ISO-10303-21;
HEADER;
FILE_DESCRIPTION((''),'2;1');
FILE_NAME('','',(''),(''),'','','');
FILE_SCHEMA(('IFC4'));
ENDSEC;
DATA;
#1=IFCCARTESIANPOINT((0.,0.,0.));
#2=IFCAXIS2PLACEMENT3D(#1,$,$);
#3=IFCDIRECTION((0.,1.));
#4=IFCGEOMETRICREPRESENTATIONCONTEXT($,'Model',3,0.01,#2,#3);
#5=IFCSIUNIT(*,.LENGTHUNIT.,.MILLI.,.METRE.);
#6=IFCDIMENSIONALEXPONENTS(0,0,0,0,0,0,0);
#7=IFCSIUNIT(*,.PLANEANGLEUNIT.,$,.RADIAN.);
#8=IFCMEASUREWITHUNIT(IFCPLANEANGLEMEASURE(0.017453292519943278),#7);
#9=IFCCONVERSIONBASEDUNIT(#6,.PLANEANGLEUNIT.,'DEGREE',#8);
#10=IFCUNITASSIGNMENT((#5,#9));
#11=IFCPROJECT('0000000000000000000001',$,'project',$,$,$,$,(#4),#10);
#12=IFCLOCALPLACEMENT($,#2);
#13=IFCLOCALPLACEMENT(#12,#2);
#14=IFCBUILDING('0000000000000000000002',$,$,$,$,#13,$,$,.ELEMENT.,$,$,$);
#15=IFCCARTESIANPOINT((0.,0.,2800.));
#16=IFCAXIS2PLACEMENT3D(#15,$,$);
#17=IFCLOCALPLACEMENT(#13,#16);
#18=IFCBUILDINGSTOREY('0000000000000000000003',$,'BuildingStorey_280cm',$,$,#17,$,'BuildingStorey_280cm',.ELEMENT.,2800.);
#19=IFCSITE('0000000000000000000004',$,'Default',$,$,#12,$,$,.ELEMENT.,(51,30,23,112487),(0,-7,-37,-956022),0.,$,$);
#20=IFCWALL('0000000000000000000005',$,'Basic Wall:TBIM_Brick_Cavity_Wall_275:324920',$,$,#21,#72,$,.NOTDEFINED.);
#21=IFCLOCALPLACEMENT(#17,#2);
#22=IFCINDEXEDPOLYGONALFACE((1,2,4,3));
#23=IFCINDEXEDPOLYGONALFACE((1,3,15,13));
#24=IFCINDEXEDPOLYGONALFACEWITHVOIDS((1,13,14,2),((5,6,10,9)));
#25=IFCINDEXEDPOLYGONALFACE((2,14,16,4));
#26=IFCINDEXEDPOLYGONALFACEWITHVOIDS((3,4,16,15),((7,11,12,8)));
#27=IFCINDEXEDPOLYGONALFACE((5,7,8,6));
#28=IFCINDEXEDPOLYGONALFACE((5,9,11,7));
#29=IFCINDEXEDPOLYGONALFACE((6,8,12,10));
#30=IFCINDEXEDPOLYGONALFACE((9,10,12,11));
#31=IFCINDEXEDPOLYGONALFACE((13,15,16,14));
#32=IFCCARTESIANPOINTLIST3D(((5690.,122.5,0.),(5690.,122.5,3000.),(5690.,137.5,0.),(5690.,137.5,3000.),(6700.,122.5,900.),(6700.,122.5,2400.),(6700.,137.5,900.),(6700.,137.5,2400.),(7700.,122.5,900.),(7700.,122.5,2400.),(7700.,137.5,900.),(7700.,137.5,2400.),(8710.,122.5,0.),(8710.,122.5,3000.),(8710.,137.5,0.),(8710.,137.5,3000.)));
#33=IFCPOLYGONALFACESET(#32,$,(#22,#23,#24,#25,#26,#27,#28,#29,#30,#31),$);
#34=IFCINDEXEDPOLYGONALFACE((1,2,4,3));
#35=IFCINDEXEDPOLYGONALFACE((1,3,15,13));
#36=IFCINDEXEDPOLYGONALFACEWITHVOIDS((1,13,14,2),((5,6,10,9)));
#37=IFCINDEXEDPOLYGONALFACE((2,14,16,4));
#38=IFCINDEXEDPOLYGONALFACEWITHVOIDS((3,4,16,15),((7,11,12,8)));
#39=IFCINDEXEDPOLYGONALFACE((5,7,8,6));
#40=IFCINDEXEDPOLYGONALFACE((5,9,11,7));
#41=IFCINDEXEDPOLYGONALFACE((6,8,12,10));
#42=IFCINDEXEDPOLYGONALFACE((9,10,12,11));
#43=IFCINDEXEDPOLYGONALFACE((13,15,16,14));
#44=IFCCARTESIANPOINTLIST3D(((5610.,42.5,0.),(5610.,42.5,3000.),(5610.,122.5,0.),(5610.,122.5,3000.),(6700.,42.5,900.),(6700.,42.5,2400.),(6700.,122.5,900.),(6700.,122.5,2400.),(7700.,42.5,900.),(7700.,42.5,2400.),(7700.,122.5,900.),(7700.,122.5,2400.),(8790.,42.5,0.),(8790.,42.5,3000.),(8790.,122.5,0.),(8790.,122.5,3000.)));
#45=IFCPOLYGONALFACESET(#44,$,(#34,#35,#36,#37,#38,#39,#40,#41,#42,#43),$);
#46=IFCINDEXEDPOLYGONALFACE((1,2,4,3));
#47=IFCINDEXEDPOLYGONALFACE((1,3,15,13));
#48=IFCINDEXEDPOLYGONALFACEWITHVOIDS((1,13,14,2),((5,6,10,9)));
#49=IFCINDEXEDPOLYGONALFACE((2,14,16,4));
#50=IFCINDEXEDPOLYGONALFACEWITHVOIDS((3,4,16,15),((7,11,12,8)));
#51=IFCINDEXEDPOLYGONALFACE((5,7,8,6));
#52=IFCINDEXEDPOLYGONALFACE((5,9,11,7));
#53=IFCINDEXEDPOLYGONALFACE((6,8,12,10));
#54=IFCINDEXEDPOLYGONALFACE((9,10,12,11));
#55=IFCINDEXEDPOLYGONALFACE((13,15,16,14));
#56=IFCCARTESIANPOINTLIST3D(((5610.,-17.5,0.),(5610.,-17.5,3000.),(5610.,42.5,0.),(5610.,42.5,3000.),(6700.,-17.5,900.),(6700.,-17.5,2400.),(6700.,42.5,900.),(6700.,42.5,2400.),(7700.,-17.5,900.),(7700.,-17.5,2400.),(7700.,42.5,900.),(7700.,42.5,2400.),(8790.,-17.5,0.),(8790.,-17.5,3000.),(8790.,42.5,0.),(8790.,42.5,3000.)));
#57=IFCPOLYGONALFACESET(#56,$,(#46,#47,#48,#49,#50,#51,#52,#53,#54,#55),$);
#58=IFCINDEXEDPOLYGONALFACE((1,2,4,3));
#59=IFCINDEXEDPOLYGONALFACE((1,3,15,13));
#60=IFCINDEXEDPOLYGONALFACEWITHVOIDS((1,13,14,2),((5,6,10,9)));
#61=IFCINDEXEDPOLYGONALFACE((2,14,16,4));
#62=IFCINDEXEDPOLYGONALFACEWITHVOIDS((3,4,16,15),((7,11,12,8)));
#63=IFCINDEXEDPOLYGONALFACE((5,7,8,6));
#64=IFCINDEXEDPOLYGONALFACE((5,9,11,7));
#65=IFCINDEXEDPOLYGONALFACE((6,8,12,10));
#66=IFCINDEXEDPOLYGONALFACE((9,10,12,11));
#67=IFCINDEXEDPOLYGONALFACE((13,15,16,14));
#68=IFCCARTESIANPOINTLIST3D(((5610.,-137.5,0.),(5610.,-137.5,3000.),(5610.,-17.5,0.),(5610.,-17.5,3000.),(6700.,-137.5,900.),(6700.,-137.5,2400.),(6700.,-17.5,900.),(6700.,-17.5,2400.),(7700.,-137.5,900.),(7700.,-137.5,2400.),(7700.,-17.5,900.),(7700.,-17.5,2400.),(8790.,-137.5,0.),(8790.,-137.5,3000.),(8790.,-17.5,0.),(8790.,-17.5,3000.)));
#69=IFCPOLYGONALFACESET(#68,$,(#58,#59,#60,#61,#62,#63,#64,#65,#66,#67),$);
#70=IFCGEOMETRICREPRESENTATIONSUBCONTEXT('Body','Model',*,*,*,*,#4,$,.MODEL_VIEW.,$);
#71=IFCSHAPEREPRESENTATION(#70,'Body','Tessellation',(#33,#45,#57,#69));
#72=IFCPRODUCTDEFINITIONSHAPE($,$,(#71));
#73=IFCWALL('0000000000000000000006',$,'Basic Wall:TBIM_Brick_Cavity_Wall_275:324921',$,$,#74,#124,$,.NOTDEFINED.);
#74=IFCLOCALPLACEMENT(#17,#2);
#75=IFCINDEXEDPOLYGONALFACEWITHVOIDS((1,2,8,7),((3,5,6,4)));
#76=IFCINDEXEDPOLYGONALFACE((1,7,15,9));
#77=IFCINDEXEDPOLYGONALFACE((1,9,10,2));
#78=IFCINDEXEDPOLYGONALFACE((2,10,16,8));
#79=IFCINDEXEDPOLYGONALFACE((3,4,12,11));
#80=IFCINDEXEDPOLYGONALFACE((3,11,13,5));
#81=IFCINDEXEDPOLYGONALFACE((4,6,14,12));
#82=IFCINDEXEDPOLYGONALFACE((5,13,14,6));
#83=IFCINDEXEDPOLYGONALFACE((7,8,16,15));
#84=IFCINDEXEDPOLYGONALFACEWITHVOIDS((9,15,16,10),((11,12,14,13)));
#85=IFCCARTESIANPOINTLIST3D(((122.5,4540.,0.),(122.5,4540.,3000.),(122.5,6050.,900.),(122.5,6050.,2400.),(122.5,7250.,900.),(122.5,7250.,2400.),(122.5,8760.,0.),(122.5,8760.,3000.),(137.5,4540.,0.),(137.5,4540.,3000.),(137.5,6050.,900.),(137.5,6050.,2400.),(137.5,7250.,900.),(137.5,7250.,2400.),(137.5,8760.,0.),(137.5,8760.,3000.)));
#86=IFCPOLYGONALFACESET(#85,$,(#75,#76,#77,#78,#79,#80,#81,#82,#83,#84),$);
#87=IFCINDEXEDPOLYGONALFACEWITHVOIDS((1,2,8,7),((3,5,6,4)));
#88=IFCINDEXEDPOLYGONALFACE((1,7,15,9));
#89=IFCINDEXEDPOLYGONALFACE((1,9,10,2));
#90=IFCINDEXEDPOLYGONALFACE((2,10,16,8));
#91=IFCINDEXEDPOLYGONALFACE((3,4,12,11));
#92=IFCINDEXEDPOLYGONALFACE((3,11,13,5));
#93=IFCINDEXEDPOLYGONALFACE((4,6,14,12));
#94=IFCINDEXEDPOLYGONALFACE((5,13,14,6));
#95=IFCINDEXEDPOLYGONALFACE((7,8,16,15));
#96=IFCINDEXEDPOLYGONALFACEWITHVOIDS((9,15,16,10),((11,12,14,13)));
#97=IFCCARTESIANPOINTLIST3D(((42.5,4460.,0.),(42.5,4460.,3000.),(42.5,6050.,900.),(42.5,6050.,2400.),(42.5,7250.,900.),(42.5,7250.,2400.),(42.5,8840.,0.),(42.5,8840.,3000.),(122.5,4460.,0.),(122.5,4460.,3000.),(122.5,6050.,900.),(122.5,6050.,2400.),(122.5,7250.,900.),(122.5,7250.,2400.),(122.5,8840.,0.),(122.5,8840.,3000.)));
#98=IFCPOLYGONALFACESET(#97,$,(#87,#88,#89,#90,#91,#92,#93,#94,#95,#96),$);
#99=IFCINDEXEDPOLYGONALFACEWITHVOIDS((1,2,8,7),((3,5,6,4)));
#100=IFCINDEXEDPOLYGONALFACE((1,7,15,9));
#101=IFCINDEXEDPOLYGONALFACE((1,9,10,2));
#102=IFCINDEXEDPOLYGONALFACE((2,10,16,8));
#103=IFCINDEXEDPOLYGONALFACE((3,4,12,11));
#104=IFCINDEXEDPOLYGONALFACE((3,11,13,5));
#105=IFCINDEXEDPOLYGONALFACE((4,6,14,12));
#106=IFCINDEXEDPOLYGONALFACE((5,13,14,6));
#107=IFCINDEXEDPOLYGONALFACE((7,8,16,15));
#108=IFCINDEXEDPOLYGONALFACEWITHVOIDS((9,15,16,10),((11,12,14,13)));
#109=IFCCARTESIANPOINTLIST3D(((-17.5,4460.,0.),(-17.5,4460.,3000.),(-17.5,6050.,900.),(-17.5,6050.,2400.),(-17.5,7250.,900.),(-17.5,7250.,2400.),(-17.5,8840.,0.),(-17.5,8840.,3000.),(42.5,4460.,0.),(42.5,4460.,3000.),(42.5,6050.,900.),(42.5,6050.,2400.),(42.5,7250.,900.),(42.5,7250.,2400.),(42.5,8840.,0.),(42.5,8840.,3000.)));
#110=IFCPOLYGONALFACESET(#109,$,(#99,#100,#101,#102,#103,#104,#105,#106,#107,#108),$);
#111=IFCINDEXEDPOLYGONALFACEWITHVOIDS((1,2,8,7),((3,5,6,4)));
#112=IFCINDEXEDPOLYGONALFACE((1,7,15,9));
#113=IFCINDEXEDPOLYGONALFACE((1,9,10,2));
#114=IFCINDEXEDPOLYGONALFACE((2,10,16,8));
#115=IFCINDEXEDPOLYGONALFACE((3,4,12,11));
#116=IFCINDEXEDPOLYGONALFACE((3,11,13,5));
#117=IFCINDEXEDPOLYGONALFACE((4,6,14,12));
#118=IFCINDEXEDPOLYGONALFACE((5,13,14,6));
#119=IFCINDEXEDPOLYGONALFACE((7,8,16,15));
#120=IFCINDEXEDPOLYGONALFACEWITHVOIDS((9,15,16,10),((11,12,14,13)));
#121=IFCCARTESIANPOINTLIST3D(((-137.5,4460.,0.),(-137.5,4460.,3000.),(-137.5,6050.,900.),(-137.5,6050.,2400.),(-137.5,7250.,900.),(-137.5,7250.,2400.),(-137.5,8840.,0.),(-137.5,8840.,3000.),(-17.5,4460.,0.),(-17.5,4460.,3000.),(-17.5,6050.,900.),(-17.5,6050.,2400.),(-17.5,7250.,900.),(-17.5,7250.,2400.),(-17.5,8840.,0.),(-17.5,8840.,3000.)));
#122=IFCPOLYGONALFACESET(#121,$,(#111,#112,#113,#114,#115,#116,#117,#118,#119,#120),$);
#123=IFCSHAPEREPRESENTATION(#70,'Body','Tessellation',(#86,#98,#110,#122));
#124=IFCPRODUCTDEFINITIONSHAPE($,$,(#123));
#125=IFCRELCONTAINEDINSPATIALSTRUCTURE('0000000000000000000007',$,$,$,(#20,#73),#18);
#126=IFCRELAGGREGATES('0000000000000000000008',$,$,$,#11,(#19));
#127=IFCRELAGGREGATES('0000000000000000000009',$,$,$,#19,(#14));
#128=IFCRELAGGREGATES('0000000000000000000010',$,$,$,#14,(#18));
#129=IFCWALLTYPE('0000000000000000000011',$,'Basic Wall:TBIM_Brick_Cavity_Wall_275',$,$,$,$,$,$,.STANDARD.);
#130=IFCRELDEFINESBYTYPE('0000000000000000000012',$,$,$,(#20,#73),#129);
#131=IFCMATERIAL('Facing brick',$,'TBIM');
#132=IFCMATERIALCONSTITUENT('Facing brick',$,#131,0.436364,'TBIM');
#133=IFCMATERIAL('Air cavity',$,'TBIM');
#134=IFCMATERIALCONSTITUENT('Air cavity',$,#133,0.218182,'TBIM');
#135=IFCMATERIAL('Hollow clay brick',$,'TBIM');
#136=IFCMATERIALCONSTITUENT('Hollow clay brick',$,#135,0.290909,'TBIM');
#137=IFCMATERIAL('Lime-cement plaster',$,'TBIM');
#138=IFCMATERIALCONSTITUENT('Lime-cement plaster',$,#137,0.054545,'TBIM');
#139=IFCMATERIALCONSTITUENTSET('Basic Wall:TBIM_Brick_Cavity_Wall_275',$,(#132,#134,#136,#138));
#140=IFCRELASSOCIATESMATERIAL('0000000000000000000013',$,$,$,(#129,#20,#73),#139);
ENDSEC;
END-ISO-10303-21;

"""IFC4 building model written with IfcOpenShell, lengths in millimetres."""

from ifc_helpers import new_model, entity, si_unit, converted_unit, direction, frame, origin, place, context, subcontext, project, spatial, indexed_curve, outline, extrude, material, constituent, constituent_set, type_object, element, save


model = new_model("IFC4")

# Units and contexts
model_context = context("Model", 3, precision=0.01, world=origin(), true_north=direction((0.0, 1.0)))
body_context = subcontext(model_context, "Body", "Model", "MODEL_VIEW")
ifc_project = project(units=[si_unit("LENGTHUNIT", "METRE", prefix="MILLI"), converted_unit("PLANEANGLEUNIT", "DEGREE", entity("IfcPlaneAngleMeasure", 0.017453292519943278), si_unit("PLANEANGLEUNIT", "RADIAN"), dimensions=[0, 0, 0, 0, 0, 0, 0])], contexts=[model_context])

# Site, building, storey
site_placement = place(None, origin())
site = spatial("IfcSite", under=ifc_project, at=site_placement, Name="Default", CompositionType="ELEMENT", RefLatitude=(51, 30, 23, 112487), RefLongitude=(0, -7, -37, -956022), RefElevation=0.0)
building_placement = place(site_placement, origin())
building = spatial("IfcBuilding", under=site, at=building_placement, CompositionType="ELEMENT")
storey_placement = place(building_placement, frame((0.0, 0.0, 2800.0)))
storey = spatial("IfcBuildingStorey", under=building, at=storey_placement, Name="BuildingStorey_280cm", LongName="BuildingStorey_280cm", CompositionType="ELEMENT", Elevation=2800.0)

# Shared definitions
ifc_material_1 = material(Name="Lime-cement plaster", Category="TBIM")

# Wall, opening
ifc_material_2 = material(Name="Facing brick", Category="TBIM")
ifc_constituent_1 = constituent(ifc_material_2, Name="Facing brick", Category="TBIM", fraction=0.436364)
ifc_material_3 = material(Name="Air cavity", Category="TBIM")
ifc_constituent_2 = constituent(ifc_material_3, Name="Air cavity", Category="TBIM", fraction=0.218182)
ifc_material_4 = material(Name="Hollow clay brick", Category="TBIM")
ifc_constituent_3 = constituent(ifc_material_4, Name="Hollow clay brick", Category="TBIM", fraction=0.290909)
ifc_constituent_4 = constituent(ifc_material_1, Name="Lime-cement plaster", Category="TBIM", fraction=0.054545)
ifc_constituent_set_1 = constituent_set(constituents=[ifc_constituent_1, ifc_constituent_2, ifc_constituent_3, ifc_constituent_4], Name="Basic Wall:TBIM_Brick_Cavity_Wall_275")
wall_type_1 = type_object("IfcWallType", Name="Basic Wall:TBIM_Brick_Cavity_Wall_275", PredefinedType="STANDARD", material=ifc_constituent_set_1)
wall_1_placement = place(storey_placement, frame((5595.0, 0.0, 0.0)))
wall_1 = element("IfcWall", 1, at=wall_1_placement, inside=storey, type_object=wall_type_1, material=ifc_constituent_set_1, Name="Basic Wall:TBIM_Brick_Cavity_Wall_275:324920", PredefinedType="NOTDEFINED", context=body_context, shape_type="SweptSolid", body=[
    extrude(outline(indexed_curve([(-1500.0, -1510.0), (1500.0, -1510.0), (1500.0, 1510.0), (-1500.0, 1510.0), (-1500.0, -1510.0)], self_intersect=False), holes=[indexed_curve([(-600.0, -500.0), (-600.0, 500.0), (900.0, 500.0), (900.0, -500.0), (-600.0, -500.0)], self_intersect=False)]), frame((1605.0, 122.5, 1500.0), z_axis=(0.0, 1.0, 0.0), x_axis=(0.0, 0.0, 1.0)), (0.0, 0.0, 1.0), 15.0),
    extrude(outline(indexed_curve([(-1500.0, -1590.0), (1500.0, -1590.0), (1500.0, 1590.0), (-1500.0, 1590.0), (-1500.0, -1590.0)], self_intersect=False), holes=[indexed_curve([(-600.0, -500.0), (-600.0, 500.0), (900.0, 500.0), (900.0, -500.0), (-600.0, -500.0)], self_intersect=False)]), frame((1605.0, 42.5, 1500.0), z_axis=(0.0, 1.0, 0.0), x_axis=(0.0, 0.0, 1.0)), (0.0, 0.0, 1.0), 80.0),
    extrude(outline(indexed_curve([(-1500.0, -1590.0), (1500.0, -1590.0), (1500.0, 1590.0), (-1500.0, 1590.0), (-1500.0, -1590.0)], self_intersect=False), holes=[indexed_curve([(-600.0, -500.0), (-600.0, 500.0), (900.0, 500.0), (900.0, -500.0), (-600.0, -500.0)], self_intersect=False)]), frame((1605.0, -17.5, 1500.0), z_axis=(0.0, 1.0, 0.0), x_axis=(0.0, 0.0, 1.0)), (0.0, 0.0, 1.0), 60.0),
    extrude(outline(indexed_curve([(-1500.0, -1590.0), (1500.0, -1590.0), (1500.0, 1590.0), (-1500.0, 1590.0), (-1500.0, -1590.0)], self_intersect=False), holes=[indexed_curve([(900.0, -500.0), (-600.0, -500.0), (-600.0, 500.0), (900.0, 500.0), (900.0, -500.0)], self_intersect=False)]), frame((1605.0, -137.5, 1500.0), z_axis=(0.0, 1.0, 0.0), x_axis=(0.0, 0.0, 1.0)), (0.0, 0.0, 1.0), 120.0),
])
opening_1_placement = place(wall_1_placement, frame((1105.0, -137.5, 900.0)))
element("IfcOpeningElement", 2, at=opening_1_placement, cuts=wall_1, PredefinedType="OPENING", context=body_context, shape_type="SweptSolid", body=[
    extrude(outline(indexed_curve([(1500.0, 0.0), (1500.0, 1000.0), (0.0, 1000.0), (0.0, 0.0), (1500.0, 0.0)], self_intersect=False)), frame((0.0, 0.0, 0.0), z_axis=(0.0, 1.0, 0.0), x_axis=(0.0, 0.0, 1.0)), (0.0, 0.0, 1.0), 275.0),
])

# Wall, openings
wall_2_placement = place(storey_placement, frame((0.0, 4445.0, 0.0), z_axis=(0.0, 0.0, 1.0), x_axis=(0.0, 1.0, 0.0)))
wall_2 = element("IfcWall", 3, at=wall_2_placement, inside=storey, type_object=wall_type_1, material=ifc_constituent_set_1, Name="Basic Wall:TBIM_Brick_Cavity_Wall_275:324921", PredefinedType="NOTDEFINED", context=body_context, shape_type="SweptSolid", body=[
    extrude(outline(indexed_curve([(-2095.0, -5.0), (2095.0, -5.0), (2110.0, -5.0), (2110.0, 10.0), (-2110.0, 10.0), (-2110.0, -5.0), (-2095.0, -5.0)], self_intersect=False)), frame((2205.0, -132.5, 0.0)), (0.0, 0.0, 1.0), 3000.0),
    extrude(outline(indexed_curve([(-1500.0, -2190.0), (1500.0, -2190.0), (1500.0, 2190.0), (-1500.0, 2190.0), (-1500.0, -2190.0)], self_intersect=False), holes=[indexed_curve([(-900.0, -600.0), (-900.0, 600.0), (600.0, 600.0), (600.0, -600.0), (-900.0, -600.0)], self_intersect=False)]), frame((2205.0, -42.5, 1500.0), z_axis=(0.0, -1.0, 0.0), x_axis=(0.0, 0.0, -1.0)), (0.0, 0.0, 1.0), 80.0),
    extrude(outline(indexed_curve([(-1500.0, -2190.0), (1500.0, -2190.0), (1500.0, 2190.0), (-1500.0, 2190.0), (-1500.0, -2190.0)], self_intersect=False), holes=[indexed_curve([(-900.0, -600.0), (-900.0, 600.0), (600.0, 600.0), (600.0, -600.0), (-900.0, -600.0)], self_intersect=False)]), frame((2205.0, 17.5, 1500.0), z_axis=(0.0, -1.0, 0.0), x_axis=(0.0, 0.0, -1.0)), (0.0, 0.0, 1.0), 60.0),
    extrude(outline(indexed_curve([(-60.0, -2190.0), (60.0, -2190.0), (60.0, 2190.0), (-60.0, 2190.0), (-60.0, -2190.0)], self_intersect=False)), frame((2205.0, 77.5, 0.0), z_axis=(0.0, 0.0, 1.0), x_axis=(0.0, -1.0, 0.0)), (0.0, 0.0, 1.0), 3000.0),
])
opening_2_placement = place(storey_placement, frame((0.0, 4445.0, 0.0), z_axis=(0.0, 0.0, 1.0), x_axis=(0.0, 1.0, 0.0)))
element("IfcOpeningElement", 4, at=opening_2_placement, cuts=wall_2, PredefinedType="OPENING", context=body_context, shape_type="SweptSolid", body=[
    extrude(outline(indexed_curve([(-750.0, -600.0), (750.0, -600.0), (750.0, 600.0), (-750.0, 600.0), (-750.0, -600.0)], self_intersect=False)), frame((2205.0, 17.5, 1650.0), z_axis=(0.0, 1.0, 0.0), x_axis=(0.0, 0.0, 1.0)), (0.0, 0.0, 1.0), 120.0),
])
opening_3_placement = place(storey_placement, frame((0.0, 4445.0, 0.0), z_axis=(0.0, 0.0, 1.0), x_axis=(0.0, 1.0, 0.0)))
element("IfcOpeningElement", 5, at=opening_3_placement, cuts=wall_2, PredefinedType="OPENING", context=body_context, shape_type="SweptSolid", body=[
    extrude(outline(indexed_curve([(-600.0, -750.0), (600.0, -750.0), (600.0, 750.0), (-600.0, 750.0), (-600.0, -750.0)], self_intersect=False)), frame((2205.0, -137.5, 1650.0), z_axis=(0.0, 1.0, 0.0), x_axis=(1.0, 0.0, 0.0)), (0.0, 0.0, 1.0), 15.0),
])
opening_4_placement = place(wall_2_placement, frame((1605.0, -137.5, 900.0)))
element("IfcOpeningElement", 6, at=opening_4_placement, cuts=wall_2, PredefinedType="OPENING", context=body_context, shape_type="SweptSolid", body=[
    extrude(outline(indexed_curve([(1500.0, 0.0), (1500.0, 1200.0), (0.0, 1200.0), (0.0, 0.0), (1500.0, 0.0)], self_intersect=False)), frame((0.0, 0.0, 0.0), z_axis=(0.0, 1.0, 0.0), x_axis=(0.0, 0.0, 1.0)), (0.0, 0.0, 1.0), 275.0),
])

save(model, "model.ifc")
